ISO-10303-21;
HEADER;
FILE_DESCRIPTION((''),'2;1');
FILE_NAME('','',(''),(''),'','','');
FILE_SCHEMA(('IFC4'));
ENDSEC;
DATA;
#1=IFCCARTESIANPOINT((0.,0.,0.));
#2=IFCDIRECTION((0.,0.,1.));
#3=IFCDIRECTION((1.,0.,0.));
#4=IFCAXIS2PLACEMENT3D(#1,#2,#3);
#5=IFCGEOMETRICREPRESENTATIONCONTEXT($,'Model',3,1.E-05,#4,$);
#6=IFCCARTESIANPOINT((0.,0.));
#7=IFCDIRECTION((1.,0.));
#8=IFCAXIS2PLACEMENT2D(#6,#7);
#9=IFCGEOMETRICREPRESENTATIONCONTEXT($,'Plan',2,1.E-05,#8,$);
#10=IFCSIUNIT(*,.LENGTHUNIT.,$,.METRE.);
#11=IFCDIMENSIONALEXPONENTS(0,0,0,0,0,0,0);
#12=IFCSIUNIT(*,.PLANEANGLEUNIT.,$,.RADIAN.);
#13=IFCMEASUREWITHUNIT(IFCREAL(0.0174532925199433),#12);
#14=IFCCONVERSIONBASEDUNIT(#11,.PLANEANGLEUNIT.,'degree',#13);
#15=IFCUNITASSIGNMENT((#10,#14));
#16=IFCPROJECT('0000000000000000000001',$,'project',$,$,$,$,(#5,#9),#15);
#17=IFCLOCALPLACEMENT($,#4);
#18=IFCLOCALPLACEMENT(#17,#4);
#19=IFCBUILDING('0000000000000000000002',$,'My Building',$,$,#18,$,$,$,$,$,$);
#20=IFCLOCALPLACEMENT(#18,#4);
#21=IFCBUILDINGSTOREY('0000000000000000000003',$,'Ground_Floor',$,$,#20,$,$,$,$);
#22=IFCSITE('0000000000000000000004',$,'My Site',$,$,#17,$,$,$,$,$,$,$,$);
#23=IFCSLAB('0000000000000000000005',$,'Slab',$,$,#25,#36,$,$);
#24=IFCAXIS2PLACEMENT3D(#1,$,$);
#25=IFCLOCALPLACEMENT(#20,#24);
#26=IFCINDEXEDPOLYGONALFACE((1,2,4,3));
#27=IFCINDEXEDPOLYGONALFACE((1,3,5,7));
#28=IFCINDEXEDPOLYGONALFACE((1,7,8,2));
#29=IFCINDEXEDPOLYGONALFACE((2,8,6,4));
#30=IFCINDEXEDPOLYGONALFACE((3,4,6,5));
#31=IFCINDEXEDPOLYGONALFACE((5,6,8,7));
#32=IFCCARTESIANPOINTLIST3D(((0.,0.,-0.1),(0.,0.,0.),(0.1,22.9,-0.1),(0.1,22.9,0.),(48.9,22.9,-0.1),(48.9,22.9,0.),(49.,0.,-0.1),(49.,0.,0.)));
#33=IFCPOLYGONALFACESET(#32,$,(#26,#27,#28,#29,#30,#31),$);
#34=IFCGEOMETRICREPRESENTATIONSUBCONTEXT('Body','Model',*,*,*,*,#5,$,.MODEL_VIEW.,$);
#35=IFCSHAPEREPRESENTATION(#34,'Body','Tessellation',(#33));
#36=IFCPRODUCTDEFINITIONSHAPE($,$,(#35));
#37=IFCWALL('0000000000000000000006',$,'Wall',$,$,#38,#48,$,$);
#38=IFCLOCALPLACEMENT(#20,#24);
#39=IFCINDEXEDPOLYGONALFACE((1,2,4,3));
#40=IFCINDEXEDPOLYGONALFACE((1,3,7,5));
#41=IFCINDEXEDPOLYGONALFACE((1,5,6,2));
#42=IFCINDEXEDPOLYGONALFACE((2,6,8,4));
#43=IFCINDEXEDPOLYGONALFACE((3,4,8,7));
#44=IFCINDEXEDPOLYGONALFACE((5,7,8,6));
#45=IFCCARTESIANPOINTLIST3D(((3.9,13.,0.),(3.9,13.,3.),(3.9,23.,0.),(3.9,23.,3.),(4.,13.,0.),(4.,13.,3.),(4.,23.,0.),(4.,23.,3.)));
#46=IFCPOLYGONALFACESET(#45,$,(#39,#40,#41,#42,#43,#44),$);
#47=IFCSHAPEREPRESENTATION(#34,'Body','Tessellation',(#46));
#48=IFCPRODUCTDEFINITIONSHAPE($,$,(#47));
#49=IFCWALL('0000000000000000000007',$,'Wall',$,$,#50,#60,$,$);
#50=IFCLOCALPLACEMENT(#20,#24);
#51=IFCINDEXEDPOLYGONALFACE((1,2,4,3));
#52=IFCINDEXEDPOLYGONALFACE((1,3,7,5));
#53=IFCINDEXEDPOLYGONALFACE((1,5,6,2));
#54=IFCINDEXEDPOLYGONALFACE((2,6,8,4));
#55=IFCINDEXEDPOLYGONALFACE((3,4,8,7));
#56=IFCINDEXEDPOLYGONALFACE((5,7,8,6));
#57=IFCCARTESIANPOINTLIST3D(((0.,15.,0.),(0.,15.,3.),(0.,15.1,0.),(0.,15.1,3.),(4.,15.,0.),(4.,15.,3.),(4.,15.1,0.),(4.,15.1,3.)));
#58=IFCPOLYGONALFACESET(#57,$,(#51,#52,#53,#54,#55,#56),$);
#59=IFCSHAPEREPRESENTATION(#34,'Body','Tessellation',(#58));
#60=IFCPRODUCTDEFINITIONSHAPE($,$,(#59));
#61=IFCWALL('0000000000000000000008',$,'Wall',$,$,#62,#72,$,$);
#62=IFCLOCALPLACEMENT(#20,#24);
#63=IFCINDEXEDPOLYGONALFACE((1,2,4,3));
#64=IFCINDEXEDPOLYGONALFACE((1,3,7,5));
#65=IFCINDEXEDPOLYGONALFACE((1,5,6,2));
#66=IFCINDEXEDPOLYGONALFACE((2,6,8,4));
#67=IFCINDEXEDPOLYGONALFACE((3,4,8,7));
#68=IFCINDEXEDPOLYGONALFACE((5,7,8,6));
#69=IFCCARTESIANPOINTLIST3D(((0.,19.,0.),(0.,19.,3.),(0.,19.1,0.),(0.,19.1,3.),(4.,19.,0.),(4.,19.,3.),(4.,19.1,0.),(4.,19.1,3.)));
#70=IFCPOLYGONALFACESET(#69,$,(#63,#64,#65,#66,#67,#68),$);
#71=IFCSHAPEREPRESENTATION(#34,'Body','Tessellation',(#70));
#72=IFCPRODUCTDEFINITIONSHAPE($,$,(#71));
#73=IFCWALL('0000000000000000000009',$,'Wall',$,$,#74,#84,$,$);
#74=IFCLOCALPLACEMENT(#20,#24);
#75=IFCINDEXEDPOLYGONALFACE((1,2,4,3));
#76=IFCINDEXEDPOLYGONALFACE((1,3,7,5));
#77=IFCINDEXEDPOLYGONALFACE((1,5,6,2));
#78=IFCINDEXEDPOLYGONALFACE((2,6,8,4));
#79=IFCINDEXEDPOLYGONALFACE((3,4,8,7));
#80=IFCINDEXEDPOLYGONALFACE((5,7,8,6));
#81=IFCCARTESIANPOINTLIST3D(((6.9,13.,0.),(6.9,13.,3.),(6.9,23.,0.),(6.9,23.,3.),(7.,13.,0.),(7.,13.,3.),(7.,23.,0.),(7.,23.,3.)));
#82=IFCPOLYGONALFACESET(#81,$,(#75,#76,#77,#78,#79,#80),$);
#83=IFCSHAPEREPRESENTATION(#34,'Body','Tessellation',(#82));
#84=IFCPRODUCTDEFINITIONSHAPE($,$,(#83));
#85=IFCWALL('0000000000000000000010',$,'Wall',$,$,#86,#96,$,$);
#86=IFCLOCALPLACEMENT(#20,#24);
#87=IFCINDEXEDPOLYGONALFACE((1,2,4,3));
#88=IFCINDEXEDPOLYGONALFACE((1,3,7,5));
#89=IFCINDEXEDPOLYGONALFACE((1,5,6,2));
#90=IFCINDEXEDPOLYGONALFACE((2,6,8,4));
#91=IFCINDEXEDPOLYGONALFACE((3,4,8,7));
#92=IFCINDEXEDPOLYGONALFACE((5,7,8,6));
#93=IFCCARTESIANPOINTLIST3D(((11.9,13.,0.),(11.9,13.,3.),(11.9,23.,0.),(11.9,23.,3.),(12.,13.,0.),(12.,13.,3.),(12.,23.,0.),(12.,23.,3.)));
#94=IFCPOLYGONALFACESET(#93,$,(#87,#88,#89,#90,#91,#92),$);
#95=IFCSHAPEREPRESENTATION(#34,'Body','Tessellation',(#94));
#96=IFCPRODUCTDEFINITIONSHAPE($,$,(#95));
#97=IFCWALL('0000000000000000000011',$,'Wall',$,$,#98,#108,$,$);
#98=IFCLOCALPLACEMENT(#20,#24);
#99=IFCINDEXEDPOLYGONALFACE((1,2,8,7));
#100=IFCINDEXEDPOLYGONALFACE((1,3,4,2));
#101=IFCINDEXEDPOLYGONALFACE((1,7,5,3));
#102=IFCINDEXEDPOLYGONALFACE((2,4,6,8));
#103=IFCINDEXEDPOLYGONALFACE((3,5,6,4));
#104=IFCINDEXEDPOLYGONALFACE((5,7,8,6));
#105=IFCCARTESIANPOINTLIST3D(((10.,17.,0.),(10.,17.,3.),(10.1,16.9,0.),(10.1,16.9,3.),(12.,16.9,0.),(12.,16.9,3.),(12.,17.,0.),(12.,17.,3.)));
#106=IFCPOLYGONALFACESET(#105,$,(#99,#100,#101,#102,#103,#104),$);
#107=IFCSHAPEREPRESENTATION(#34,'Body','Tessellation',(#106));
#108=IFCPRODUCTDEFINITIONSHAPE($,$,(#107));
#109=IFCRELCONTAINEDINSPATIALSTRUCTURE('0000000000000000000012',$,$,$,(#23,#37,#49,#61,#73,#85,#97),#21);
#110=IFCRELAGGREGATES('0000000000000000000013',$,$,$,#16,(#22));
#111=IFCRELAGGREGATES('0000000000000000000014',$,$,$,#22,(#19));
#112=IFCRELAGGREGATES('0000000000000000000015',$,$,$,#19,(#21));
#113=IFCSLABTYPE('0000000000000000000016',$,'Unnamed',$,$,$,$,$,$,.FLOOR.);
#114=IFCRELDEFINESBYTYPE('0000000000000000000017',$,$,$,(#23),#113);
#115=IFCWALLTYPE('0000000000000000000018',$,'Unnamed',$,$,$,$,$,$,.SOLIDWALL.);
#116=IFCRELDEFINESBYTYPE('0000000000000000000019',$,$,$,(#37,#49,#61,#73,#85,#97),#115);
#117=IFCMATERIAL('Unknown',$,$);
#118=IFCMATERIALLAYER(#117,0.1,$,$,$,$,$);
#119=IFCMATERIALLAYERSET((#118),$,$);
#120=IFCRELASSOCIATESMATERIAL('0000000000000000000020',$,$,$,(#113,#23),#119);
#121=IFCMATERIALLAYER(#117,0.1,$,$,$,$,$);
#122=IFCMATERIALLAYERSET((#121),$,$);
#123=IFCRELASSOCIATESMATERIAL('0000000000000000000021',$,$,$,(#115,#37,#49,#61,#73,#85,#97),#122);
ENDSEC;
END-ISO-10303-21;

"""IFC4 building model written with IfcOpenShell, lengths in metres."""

from ifc_helpers import new_model, entity, si_unit, converted_unit, frame, origin_with_axes, origin_2d_with_axis, place, context, subcontext, project, spatial, line, indexed_curve, outline, extrude, material, layer, layer_set, layer_usage, type_object, element, save


model = new_model("IFC4")

# Units and contexts
model_context = context("Model", 3, precision=1e-05, world=origin_with_axes())
plan_context = context("Plan", 2, precision=1e-05, world=origin_2d_with_axis())
body_context_1 = subcontext(model_context, "Body", "Model", "MODEL_VIEW")
ifc_project = project(units=[si_unit("LENGTHUNIT", "METRE"), converted_unit("PLANEANGLEUNIT", "degree", entity("IfcReal", 0.0174532925199433), si_unit("PLANEANGLEUNIT", "RADIAN"), dimensions=[0, 0, 0, 0, 0, 0, 0])], contexts=[model_context, plan_context])

# Site, building, storey
site_placement = place(None, origin_with_axes())
site = spatial("IfcSite", under=ifc_project, at=site_placement, Name="My Site")
building_placement = place(site_placement, origin_with_axes())
building = spatial("IfcBuilding", under=site, at=building_placement, Name="My Building")
storey_placement = place(building_placement, origin_with_axes())
storey = spatial("IfcBuildingStorey", under=building, at=storey_placement, Name="Ground_Floor")

# Slab
ifc_material = material(Name="Unknown")
ifc_layer_1 = layer(ifc_material, 0.1)
ifc_layer_set_1 = layer_set([ifc_layer_1])
ifc_layer_usage_1 = layer_usage(ifc_layer_set_1, "AXIS3", "POSITIVE", -0.1)
slab_type = type_object("IfcSlabType", Name="Unnamed", PredefinedType="FLOOR", material=ifc_layer_set_1)
slab_placement = place(storey_placement, frame((0.1, 22.9, 0.0), z_axis=(0.0, 0.0, 1.0), x_axis=(1.0, 0.0, 0.0)))
element("IfcSlab", 1, at=slab_placement, inside=storey, type_object=slab_type, material=ifc_layer_usage_1, Name="Slab", context=body_context_1, shape_type="SweptSolid", body=[
    extrude(outline(indexed_curve([(0.0, 0.0), (48.8, 0.0), (48.9, -22.9), (-0.1, -22.9), (0.0, 0.0)])), frame((0.0, 0.0, -0.1), z_axis=(0.0, 0.0, 1.0), x_axis=(1.0, 0.0, 0.0)), (0.0, 0.0, 1.0), 0.1),
])

# Wall
ifc_layer_2 = layer(ifc_material, 0.1)
ifc_layer_set_2 = layer_set([ifc_layer_2])
ifc_layer_usage_2 = layer_usage(ifc_layer_set_2, "AXIS2", "POSITIVE", 0.0)
wall_type = type_object("IfcWallType", Name="Unnamed", PredefinedType="SOLIDWALL", material=ifc_layer_set_2)
wall_1_placement = place(storey_placement, frame((4.0, 13.0, 0.0), z_axis=(0.0, 0.0, 1.0), x_axis=(0.0, 1.0, 0.0)))
element("IfcWall", 2, at=wall_1_placement, inside=storey, type_object=wall_type, material=ifc_layer_usage_2, Name="Wall", context=body_context_1, shape_type="SweptSolid", body=[
    extrude(outline(indexed_curve([(0.0, 0.0), (0.0, 0.1), (10.0, 0.1), (10.0, 0.0)], segments=[line(1, 2, 3, 4, 1)])), origin_with_axes(), (0.0, 0.0, 1.0), 3.0),
])

# Walls
ifc_layer_usage_3 = layer_usage(ifc_layer_set_2, "AXIS2", "POSITIVE", 0.0)
wall_2_placement = place(storey_placement, frame((0.0, 15.0, 0.0), z_axis=(0.0, 0.0, 1.0), x_axis=(1.0, 0.0, 0.0)))
element("IfcWall", 3, at=wall_2_placement, inside=storey, type_object=wall_type, material=ifc_layer_usage_3, Name="Wall", context=body_context_1, shape_type="SweptSolid", body=[
    extrude(outline(indexed_curve([(0.0, 0.0), (0.0, 0.1), (4.0, 0.1), (4.0, 0.0)], segments=[line(1, 2, 3, 4, 1)])), origin_with_axes(), (0.0, 0.0, 1.0), 3.0),
])
ifc_layer_usage_4 = layer_usage(ifc_layer_set_2, "AXIS2", "POSITIVE", 0.0)
wall_3_placement = place(storey_placement, frame((0.0, 19.0, 0.0), z_axis=(0.0, 0.0, 1.0), x_axis=(1.0, 0.0, 0.0)))
element("IfcWall", 4, at=wall_3_placement, inside=storey, type_object=wall_type, material=ifc_layer_usage_4, Name="Wall", context=body_context_1, shape_type="SweptSolid", body=[
    extrude(outline(indexed_curve([(0.0, 0.0), (0.0, 0.1), (4.0, 0.1), (4.0, 0.0)], segments=[line(1, 2, 3, 4, 1)])), origin_with_axes(), (0.0, 0.0, 1.0), 3.0),
])
ifc_layer_usage_5 = layer_usage(ifc_layer_set_2, "AXIS2", "POSITIVE", 0.0)
wall_4_placement = place(storey_placement, frame((7.0, 13.0, 0.0), z_axis=(0.0, 0.0, 1.0), x_axis=(0.0, 1.0, 0.0)))
element("IfcWall", 5, at=wall_4_placement, inside=storey, type_object=wall_type, material=ifc_layer_usage_5, Name="Wall", context=body_context_1, shape_type="SweptSolid", body=[
    extrude(outline(indexed_curve([(0.0, 0.0), (0.0, 0.1), (10.0, 0.1), (10.0, 0.0)], segments=[line(1, 2, 3, 4, 1)])), origin_with_axes(), (0.0, 0.0, 1.0), 3.0),
])
ifc_layer_usage_6 = layer_usage(ifc_layer_set_2, "AXIS2", "POSITIVE", 0.0)
wall_5_placement = place(storey_placement, frame((12.0, 13.0, 0.0), z_axis=(0.0, 0.0, 1.0), x_axis=(0.0, 1.0, 0.0)))
element("IfcWall", 6, at=wall_5_placement, inside=storey, type_object=wall_type, material=ifc_layer_usage_6, Name="Wall", context=body_context_1, shape_type="SweptSolid", body=[
    extrude(outline(indexed_curve([(0.0, 0.0), (0.0, 0.1), (10.0, 0.1), (10.0, 0.0)], segments=[line(1, 2, 3, 4, 1)])), origin_with_axes(), (0.0, 0.0, 1.0), 3.0),
])
ifc_layer_usage_7 = layer_usage(ifc_layer_set_2, "AXIS2", "POSITIVE", 0.0)
wall_6_placement = place(storey_placement, frame((12.0, 17.0, 0.0), z_axis=(0.0, 0.0, 1.0), x_axis=(-1.0, 0.0, 0.0)))
element("IfcWall", 7, at=wall_6_placement, inside=storey, type_object=wall_type, material=ifc_layer_usage_7, Name="Wall", context=body_context_1, shape_type="SweptSolid", body=[
    extrude(outline(indexed_curve([(0.0, 0.0), (0.0, 0.1), (1.9, 0.1), (2.0, 0.0)], segments=[line(1, 2, 3, 4, 1)])), origin_with_axes(), (0.0, 0.0, 1.0), 3.0),
])

save(model, "model.ifc")
